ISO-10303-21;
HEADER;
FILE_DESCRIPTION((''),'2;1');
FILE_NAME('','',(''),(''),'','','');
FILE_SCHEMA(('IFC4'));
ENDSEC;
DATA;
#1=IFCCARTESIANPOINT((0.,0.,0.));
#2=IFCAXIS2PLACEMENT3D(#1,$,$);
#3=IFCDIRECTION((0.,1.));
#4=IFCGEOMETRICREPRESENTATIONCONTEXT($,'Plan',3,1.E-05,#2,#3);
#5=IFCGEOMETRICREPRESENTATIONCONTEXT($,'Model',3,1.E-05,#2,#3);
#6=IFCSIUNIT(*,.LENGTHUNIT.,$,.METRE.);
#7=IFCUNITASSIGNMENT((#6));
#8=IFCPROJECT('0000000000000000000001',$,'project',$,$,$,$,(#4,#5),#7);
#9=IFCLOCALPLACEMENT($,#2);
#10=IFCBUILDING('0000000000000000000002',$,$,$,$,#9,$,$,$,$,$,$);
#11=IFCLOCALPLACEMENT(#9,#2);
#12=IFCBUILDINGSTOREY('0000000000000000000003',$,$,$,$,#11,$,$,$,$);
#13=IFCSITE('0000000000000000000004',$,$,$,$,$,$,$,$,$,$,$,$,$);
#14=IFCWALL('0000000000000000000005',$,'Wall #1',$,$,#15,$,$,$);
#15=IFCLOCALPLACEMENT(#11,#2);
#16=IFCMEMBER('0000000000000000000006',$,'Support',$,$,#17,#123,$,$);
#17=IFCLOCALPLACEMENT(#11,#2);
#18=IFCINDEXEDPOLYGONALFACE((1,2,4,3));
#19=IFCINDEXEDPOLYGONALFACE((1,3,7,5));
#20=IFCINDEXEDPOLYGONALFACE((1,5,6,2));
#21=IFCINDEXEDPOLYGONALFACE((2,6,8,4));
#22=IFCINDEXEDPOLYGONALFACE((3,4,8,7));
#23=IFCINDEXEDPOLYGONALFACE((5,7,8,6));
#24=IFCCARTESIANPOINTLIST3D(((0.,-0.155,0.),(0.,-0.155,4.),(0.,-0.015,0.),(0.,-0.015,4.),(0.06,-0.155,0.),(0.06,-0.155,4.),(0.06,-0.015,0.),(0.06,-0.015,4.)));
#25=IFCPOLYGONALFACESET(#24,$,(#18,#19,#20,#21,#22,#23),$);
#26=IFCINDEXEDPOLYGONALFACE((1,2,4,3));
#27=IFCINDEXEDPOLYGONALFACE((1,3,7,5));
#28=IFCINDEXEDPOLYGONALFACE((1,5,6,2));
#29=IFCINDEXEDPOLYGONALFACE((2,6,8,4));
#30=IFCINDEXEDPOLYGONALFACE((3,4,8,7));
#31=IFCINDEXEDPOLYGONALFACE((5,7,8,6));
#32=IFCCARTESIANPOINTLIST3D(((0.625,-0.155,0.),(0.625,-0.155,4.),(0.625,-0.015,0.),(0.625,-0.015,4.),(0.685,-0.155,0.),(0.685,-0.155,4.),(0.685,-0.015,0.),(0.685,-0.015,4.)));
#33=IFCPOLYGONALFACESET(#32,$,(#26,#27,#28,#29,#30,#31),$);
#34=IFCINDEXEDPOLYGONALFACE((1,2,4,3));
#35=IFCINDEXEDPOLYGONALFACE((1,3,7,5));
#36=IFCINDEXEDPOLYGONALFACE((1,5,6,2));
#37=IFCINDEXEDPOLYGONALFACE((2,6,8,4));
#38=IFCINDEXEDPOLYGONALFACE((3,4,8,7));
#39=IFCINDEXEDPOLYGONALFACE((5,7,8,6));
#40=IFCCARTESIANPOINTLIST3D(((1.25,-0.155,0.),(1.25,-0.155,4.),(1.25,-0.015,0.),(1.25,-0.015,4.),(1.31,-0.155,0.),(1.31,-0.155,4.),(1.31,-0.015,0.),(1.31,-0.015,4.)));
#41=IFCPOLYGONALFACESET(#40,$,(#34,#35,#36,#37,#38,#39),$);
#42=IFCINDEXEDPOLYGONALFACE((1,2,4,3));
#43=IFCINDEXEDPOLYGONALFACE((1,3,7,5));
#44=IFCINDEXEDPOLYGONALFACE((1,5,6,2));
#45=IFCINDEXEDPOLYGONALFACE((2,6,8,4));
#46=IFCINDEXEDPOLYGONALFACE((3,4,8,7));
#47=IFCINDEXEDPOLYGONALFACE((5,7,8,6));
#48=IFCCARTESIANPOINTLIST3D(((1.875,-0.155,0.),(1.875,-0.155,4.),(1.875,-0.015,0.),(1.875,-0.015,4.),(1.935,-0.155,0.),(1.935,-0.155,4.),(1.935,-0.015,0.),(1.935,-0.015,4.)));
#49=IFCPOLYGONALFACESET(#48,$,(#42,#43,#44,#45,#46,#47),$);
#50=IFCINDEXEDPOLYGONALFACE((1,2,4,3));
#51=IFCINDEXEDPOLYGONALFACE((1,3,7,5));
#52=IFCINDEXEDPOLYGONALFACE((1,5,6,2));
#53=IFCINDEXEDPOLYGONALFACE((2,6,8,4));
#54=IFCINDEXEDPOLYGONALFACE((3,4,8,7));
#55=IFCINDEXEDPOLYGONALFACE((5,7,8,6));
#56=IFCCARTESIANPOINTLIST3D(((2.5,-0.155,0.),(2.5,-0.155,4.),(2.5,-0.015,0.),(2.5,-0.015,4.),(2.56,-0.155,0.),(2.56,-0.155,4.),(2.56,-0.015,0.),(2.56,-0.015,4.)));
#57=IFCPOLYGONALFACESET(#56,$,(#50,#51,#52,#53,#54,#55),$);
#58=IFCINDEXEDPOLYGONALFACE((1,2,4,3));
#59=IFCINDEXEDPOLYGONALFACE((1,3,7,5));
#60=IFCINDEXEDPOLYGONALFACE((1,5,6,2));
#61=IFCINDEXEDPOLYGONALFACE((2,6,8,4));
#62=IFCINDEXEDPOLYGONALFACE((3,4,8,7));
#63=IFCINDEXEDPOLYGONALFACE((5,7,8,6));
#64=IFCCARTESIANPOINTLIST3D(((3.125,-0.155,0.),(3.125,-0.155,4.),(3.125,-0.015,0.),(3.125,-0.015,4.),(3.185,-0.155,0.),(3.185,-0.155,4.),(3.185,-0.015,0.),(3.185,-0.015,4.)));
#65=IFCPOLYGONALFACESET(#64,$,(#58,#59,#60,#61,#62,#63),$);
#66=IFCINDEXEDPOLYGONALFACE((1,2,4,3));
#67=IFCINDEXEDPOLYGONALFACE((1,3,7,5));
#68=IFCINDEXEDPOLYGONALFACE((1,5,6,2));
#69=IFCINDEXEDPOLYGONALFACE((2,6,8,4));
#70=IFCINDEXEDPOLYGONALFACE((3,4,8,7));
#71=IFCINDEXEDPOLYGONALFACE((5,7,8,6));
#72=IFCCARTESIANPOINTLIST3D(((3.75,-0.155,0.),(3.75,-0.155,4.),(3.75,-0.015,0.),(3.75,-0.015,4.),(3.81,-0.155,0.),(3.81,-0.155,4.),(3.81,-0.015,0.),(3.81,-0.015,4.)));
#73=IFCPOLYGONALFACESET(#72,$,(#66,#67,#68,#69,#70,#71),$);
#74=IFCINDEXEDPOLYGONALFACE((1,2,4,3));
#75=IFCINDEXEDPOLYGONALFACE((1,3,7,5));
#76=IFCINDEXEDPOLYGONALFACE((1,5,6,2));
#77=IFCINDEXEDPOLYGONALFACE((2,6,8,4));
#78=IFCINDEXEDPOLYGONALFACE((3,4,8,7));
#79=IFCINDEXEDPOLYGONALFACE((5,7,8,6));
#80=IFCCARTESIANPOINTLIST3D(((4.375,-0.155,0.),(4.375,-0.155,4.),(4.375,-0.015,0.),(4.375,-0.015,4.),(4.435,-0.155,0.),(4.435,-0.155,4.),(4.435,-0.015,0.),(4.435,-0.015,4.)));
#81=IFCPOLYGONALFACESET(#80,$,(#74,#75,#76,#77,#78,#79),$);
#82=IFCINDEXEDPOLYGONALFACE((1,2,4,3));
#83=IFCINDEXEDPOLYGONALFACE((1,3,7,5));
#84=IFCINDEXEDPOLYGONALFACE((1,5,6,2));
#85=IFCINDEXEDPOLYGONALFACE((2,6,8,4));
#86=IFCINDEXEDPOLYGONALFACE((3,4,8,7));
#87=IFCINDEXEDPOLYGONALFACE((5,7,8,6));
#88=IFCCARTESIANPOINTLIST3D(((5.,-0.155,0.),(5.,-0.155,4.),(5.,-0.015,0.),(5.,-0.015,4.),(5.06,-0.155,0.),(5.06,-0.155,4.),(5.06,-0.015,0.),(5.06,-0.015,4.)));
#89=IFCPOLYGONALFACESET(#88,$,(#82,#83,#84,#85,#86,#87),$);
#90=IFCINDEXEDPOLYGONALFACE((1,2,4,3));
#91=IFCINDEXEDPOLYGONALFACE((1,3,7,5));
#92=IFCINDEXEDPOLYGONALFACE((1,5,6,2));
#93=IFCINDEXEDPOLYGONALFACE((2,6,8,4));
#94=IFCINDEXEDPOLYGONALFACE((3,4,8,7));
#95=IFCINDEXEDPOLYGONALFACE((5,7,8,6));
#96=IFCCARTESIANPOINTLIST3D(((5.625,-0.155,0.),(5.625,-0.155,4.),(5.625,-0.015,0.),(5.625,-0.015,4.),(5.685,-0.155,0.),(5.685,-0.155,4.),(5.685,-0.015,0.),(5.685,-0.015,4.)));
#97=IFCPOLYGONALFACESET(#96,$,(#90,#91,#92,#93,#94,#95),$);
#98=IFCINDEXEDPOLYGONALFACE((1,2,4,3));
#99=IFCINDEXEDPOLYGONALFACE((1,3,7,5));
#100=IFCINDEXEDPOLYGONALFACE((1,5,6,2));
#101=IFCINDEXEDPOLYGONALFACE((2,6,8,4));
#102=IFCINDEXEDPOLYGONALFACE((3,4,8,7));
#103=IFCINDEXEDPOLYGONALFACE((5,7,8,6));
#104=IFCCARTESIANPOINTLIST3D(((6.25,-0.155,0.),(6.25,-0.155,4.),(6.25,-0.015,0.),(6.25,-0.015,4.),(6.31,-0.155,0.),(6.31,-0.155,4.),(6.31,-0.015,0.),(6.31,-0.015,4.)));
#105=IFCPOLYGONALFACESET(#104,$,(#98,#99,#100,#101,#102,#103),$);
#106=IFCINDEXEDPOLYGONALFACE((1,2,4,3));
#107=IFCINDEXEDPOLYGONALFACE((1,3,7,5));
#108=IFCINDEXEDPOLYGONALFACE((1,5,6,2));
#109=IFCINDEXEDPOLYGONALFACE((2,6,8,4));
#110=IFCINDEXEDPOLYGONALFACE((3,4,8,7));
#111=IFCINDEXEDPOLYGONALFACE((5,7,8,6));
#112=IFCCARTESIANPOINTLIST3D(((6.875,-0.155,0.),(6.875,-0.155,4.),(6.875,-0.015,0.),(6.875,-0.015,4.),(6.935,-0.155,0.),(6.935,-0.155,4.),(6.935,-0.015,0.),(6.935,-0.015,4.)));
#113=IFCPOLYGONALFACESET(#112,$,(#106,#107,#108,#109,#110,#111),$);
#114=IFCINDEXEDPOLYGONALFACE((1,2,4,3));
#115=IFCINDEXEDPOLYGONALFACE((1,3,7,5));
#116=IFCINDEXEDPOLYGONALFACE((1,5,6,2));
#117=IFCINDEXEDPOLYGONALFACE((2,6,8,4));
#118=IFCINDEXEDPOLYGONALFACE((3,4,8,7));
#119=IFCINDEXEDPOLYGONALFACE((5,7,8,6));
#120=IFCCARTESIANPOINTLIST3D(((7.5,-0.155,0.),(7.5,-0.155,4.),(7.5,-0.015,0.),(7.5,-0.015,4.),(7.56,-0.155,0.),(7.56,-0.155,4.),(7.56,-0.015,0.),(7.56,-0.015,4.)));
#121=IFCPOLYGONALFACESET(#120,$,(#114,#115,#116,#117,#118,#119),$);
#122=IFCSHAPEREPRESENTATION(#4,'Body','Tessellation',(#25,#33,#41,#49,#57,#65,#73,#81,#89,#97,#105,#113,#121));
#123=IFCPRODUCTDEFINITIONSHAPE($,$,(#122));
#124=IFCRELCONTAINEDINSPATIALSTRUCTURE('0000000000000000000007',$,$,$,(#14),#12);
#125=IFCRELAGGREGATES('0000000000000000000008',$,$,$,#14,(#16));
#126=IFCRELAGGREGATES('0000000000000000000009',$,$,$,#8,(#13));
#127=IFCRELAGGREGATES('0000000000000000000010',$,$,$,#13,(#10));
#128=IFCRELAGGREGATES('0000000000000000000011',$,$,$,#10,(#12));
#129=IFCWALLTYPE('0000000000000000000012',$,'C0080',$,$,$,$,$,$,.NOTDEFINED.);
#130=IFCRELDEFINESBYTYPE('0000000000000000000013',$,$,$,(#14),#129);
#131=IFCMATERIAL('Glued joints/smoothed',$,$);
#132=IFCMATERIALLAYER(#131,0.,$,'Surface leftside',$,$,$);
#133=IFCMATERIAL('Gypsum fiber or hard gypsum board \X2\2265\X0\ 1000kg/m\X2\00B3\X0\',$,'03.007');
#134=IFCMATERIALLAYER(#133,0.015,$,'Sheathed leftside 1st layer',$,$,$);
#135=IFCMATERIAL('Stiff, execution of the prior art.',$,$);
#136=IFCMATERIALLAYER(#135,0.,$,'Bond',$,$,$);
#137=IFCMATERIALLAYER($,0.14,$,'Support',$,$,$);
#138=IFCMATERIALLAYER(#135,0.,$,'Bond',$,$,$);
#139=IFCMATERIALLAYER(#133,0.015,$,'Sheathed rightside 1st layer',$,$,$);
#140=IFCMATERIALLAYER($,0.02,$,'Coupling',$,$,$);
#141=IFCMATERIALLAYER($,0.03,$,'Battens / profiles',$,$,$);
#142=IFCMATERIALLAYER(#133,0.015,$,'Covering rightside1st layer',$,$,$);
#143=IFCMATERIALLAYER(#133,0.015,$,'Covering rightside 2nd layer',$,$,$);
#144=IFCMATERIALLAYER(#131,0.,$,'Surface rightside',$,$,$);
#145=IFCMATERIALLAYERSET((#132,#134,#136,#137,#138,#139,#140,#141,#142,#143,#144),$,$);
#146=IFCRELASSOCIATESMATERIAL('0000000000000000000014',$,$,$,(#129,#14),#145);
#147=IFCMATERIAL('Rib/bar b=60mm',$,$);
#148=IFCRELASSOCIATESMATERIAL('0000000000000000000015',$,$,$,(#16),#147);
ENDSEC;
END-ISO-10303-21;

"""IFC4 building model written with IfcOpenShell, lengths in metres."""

from ifc_helpers import new_model, si_unit, direction, frame, frame_2d, origin, place, context, project, spatial, rectangle, extrude, material, layer, layer_set, type_object, element, aggregate, save


model = new_model("IFC4")

# Units and contexts
plan_context = context("Plan", 3, precision=1e-05, world=origin(), true_north=direction((0.0, 1.0)))
model_context = context("Model", 3, precision=1e-05, world=origin(), true_north=direction((0.0, 1.0)))
ifc_project = project(units=[si_unit("LENGTHUNIT", "METRE")], contexts=[plan_context, model_context])

# Site, building, storey
site = spatial("IfcSite", under=ifc_project)
building_placement = place(None, origin())
building = spatial("IfcBuilding", under=site, at=building_placement)
storey_placement = place(building_placement, origin())
storey = spatial("IfcBuildingStorey", under=building, at=storey_placement)

# Wall, member
ifc_material_1 = material(Name="Glued joints/smoothed")
ifc_layer_1 = layer(ifc_material_1, 0.0, Name="Surface leftside")
ifc_material_2 = material(Name="Gypsum fiber or hard gypsum board ≥ 1000kg/m³", Category="03.007")
ifc_layer_2 = layer(ifc_material_2, 0.015, Name="Sheathed leftside 1st layer")
ifc_material_3 = material(Name="Stiff, execution of the prior art.")
ifc_layer_3 = layer(ifc_material_3, 0.0, Name="Bond")
ifc_layer_4 = layer(None, 0.14, Name="Support")
ifc_layer_5 = layer(ifc_material_3, 0.0, Name="Bond")
ifc_layer_6 = layer(ifc_material_2, 0.015, Name="Sheathed rightside 1st layer")
ifc_layer_7 = layer(None, 0.02, Name="Coupling")
ifc_layer_8 = layer(None, 0.03, Name="Battens / profiles")
ifc_layer_9 = layer(ifc_material_2, 0.015, Name="Covering rightside1st layer")
ifc_layer_10 = layer(ifc_material_2, 0.015, Name="Covering rightside 2nd layer")
ifc_layer_11 = layer(ifc_material_1, 0.0, Name="Surface rightside")
ifc_layer_set = layer_set([ifc_layer_1, ifc_layer_2, ifc_layer_3, ifc_layer_4, ifc_layer_5, ifc_layer_6, ifc_layer_7, ifc_layer_8, ifc_layer_9, ifc_layer_10, ifc_layer_11])
wall_type = type_object("IfcWallType", Name="C0080", PredefinedType="NOTDEFINED", material=ifc_layer_set)
wall_placement = place(None, frame((0.0, 0.0, 0.0), z_axis=(0.0, -1.0, 0.0), x_axis=(1.0, 0.0, 0.0)))
wall = element("IfcWall", 1, at=wall_placement, inside=storey, type_object=wall_type, material=ifc_layer_set, Name="Wall #1")
ifc_material_4 = material(Name="Rib/bar b=60mm")
member_1_placement = place(wall_placement, origin())
member_1 = element("IfcMember", 2, at=member_1_placement, material=ifc_material_4, Name="Support", context=plan_context, shape_type="SweptSolid", body=[
    extrude(rectangle(XDim=0.06, YDim=0.14, at=frame_2d((0.03, 0.07), x_axis=(1.0, 0.0))), frame((0.0, 4.0, 0.015), z_axis=(0.0, -1.0, 0.0), x_axis=(1.0, 0.0, 0.0)), (0.0, 0.0, 1.0), 4.0),
    extrude(rectangle(XDim=0.06, YDim=0.14, at=frame_2d((0.03, 0.07), x_axis=(1.0, 0.0))), frame((0.625, 4.0, 0.015), z_axis=(0.0, -1.0, 0.0), x_axis=(1.0, 0.0, 0.0)), (0.0, 0.0, 1.0), 4.0),
    extrude(rectangle(XDim=0.06, YDim=0.14, at=frame_2d((0.03, 0.07), x_axis=(1.0, 0.0))), frame((1.25, 4.0, 0.015), z_axis=(0.0, -1.0, 0.0), x_axis=(1.0, 0.0, 0.0)), (0.0, 0.0, 1.0), 4.0),
    extrude(rectangle(XDim=0.06, YDim=0.14, at=frame_2d((0.03, 0.07), x_axis=(1.0, 0.0))), frame((1.875, 4.0, 0.015), z_axis=(0.0, -1.0, 0.0), x_axis=(1.0, 0.0, 0.0)), (0.0, 0.0, 1.0), 4.0),
    extrude(rectangle(XDim=0.06, YDim=0.14, at=frame_2d((0.03, 0.07), x_axis=(1.0, 0.0))), frame((2.5, 4.0, 0.015), z_axis=(0.0, -1.0, 0.0), x_axis=(1.0, 0.0, 0.0)), (0.0, 0.0, 1.0), 4.0),
    extrude(rectangle(XDim=0.06, YDim=0.14, at=frame_2d((0.03, 0.07), x_axis=(1.0, 0.0))), frame((3.125, 4.0, 0.015), z_axis=(0.0, -1.0, 0.0), x_axis=(1.0, 0.0, 0.0)), (0.0, 0.0, 1.0), 4.0),
    extrude(rectangle(XDim=0.06, YDim=0.14, at=frame_2d((0.03, 0.07), x_axis=(1.0, 0.0))), frame((3.75, 4.0, 0.015), z_axis=(0.0, -1.0, 0.0), x_axis=(1.0, 0.0, 0.0)), (0.0, 0.0, 1.0), 4.0),
    extrude(rectangle(XDim=0.06, YDim=0.14, at=frame_2d((0.03, 0.07), x_axis=(1.0, 0.0))), frame((4.375, 4.0, 0.015), z_axis=(0.0, -1.0, 0.0), x_axis=(1.0, 0.0, 0.0)), (0.0, 0.0, 1.0), 4.0),
    extrude(rectangle(XDim=0.06, YDim=0.14, at=frame_2d((0.03, 0.07), x_axis=(1.0, 0.0))), frame((5.0, 4.0, 0.015), z_axis=(0.0, -1.0, 0.0), x_axis=(1.0, 0.0, 0.0)), (0.0, 0.0, 1.0), 4.0),
    extrude(rectangle(XDim=0.06, YDim=0.14, at=frame_2d((0.03, 0.07), x_axis=(1.0, 0.0))), frame((5.625, 4.0, 0.015), z_axis=(0.0, -1.0, 0.0), x_axis=(1.0, 0.0, 0.0)), (0.0, 0.0, 1.0), 4.0),
    extrude(rectangle(XDim=0.06, YDim=0.14, at=frame_2d((0.03, 0.07), x_axis=(1.0, 0.0))), frame((6.25, 4.0, 0.015), z_axis=(0.0, -1.0, 0.0), x_axis=(1.0, 0.0, 0.0)), (0.0, 0.0, 1.0), 4.0),
    extrude(rectangle(XDim=0.06, YDim=0.14, at=frame_2d((0.03, 0.07), x_axis=(1.0, 0.0))), frame((6.875, 4.0, 0.015), z_axis=(0.0, -1.0, 0.0), x_axis=(1.0, 0.0, 0.0)), (0.0, 0.0, 1.0), 4.0),
    extrude(rectangle(XDim=0.06, YDim=0.14, at=frame_2d((0.03, 0.07), x_axis=(1.0, 0.0))), frame((7.5, 4.0, 0.015), z_axis=(0.0, -1.0, 0.0), x_axis=(1.0, 0.0, 0.0)), (0.0, 0.0, 1.0), 4.0),
])
aggregate(wall, [member_1])

save(model, "model.ifc")
